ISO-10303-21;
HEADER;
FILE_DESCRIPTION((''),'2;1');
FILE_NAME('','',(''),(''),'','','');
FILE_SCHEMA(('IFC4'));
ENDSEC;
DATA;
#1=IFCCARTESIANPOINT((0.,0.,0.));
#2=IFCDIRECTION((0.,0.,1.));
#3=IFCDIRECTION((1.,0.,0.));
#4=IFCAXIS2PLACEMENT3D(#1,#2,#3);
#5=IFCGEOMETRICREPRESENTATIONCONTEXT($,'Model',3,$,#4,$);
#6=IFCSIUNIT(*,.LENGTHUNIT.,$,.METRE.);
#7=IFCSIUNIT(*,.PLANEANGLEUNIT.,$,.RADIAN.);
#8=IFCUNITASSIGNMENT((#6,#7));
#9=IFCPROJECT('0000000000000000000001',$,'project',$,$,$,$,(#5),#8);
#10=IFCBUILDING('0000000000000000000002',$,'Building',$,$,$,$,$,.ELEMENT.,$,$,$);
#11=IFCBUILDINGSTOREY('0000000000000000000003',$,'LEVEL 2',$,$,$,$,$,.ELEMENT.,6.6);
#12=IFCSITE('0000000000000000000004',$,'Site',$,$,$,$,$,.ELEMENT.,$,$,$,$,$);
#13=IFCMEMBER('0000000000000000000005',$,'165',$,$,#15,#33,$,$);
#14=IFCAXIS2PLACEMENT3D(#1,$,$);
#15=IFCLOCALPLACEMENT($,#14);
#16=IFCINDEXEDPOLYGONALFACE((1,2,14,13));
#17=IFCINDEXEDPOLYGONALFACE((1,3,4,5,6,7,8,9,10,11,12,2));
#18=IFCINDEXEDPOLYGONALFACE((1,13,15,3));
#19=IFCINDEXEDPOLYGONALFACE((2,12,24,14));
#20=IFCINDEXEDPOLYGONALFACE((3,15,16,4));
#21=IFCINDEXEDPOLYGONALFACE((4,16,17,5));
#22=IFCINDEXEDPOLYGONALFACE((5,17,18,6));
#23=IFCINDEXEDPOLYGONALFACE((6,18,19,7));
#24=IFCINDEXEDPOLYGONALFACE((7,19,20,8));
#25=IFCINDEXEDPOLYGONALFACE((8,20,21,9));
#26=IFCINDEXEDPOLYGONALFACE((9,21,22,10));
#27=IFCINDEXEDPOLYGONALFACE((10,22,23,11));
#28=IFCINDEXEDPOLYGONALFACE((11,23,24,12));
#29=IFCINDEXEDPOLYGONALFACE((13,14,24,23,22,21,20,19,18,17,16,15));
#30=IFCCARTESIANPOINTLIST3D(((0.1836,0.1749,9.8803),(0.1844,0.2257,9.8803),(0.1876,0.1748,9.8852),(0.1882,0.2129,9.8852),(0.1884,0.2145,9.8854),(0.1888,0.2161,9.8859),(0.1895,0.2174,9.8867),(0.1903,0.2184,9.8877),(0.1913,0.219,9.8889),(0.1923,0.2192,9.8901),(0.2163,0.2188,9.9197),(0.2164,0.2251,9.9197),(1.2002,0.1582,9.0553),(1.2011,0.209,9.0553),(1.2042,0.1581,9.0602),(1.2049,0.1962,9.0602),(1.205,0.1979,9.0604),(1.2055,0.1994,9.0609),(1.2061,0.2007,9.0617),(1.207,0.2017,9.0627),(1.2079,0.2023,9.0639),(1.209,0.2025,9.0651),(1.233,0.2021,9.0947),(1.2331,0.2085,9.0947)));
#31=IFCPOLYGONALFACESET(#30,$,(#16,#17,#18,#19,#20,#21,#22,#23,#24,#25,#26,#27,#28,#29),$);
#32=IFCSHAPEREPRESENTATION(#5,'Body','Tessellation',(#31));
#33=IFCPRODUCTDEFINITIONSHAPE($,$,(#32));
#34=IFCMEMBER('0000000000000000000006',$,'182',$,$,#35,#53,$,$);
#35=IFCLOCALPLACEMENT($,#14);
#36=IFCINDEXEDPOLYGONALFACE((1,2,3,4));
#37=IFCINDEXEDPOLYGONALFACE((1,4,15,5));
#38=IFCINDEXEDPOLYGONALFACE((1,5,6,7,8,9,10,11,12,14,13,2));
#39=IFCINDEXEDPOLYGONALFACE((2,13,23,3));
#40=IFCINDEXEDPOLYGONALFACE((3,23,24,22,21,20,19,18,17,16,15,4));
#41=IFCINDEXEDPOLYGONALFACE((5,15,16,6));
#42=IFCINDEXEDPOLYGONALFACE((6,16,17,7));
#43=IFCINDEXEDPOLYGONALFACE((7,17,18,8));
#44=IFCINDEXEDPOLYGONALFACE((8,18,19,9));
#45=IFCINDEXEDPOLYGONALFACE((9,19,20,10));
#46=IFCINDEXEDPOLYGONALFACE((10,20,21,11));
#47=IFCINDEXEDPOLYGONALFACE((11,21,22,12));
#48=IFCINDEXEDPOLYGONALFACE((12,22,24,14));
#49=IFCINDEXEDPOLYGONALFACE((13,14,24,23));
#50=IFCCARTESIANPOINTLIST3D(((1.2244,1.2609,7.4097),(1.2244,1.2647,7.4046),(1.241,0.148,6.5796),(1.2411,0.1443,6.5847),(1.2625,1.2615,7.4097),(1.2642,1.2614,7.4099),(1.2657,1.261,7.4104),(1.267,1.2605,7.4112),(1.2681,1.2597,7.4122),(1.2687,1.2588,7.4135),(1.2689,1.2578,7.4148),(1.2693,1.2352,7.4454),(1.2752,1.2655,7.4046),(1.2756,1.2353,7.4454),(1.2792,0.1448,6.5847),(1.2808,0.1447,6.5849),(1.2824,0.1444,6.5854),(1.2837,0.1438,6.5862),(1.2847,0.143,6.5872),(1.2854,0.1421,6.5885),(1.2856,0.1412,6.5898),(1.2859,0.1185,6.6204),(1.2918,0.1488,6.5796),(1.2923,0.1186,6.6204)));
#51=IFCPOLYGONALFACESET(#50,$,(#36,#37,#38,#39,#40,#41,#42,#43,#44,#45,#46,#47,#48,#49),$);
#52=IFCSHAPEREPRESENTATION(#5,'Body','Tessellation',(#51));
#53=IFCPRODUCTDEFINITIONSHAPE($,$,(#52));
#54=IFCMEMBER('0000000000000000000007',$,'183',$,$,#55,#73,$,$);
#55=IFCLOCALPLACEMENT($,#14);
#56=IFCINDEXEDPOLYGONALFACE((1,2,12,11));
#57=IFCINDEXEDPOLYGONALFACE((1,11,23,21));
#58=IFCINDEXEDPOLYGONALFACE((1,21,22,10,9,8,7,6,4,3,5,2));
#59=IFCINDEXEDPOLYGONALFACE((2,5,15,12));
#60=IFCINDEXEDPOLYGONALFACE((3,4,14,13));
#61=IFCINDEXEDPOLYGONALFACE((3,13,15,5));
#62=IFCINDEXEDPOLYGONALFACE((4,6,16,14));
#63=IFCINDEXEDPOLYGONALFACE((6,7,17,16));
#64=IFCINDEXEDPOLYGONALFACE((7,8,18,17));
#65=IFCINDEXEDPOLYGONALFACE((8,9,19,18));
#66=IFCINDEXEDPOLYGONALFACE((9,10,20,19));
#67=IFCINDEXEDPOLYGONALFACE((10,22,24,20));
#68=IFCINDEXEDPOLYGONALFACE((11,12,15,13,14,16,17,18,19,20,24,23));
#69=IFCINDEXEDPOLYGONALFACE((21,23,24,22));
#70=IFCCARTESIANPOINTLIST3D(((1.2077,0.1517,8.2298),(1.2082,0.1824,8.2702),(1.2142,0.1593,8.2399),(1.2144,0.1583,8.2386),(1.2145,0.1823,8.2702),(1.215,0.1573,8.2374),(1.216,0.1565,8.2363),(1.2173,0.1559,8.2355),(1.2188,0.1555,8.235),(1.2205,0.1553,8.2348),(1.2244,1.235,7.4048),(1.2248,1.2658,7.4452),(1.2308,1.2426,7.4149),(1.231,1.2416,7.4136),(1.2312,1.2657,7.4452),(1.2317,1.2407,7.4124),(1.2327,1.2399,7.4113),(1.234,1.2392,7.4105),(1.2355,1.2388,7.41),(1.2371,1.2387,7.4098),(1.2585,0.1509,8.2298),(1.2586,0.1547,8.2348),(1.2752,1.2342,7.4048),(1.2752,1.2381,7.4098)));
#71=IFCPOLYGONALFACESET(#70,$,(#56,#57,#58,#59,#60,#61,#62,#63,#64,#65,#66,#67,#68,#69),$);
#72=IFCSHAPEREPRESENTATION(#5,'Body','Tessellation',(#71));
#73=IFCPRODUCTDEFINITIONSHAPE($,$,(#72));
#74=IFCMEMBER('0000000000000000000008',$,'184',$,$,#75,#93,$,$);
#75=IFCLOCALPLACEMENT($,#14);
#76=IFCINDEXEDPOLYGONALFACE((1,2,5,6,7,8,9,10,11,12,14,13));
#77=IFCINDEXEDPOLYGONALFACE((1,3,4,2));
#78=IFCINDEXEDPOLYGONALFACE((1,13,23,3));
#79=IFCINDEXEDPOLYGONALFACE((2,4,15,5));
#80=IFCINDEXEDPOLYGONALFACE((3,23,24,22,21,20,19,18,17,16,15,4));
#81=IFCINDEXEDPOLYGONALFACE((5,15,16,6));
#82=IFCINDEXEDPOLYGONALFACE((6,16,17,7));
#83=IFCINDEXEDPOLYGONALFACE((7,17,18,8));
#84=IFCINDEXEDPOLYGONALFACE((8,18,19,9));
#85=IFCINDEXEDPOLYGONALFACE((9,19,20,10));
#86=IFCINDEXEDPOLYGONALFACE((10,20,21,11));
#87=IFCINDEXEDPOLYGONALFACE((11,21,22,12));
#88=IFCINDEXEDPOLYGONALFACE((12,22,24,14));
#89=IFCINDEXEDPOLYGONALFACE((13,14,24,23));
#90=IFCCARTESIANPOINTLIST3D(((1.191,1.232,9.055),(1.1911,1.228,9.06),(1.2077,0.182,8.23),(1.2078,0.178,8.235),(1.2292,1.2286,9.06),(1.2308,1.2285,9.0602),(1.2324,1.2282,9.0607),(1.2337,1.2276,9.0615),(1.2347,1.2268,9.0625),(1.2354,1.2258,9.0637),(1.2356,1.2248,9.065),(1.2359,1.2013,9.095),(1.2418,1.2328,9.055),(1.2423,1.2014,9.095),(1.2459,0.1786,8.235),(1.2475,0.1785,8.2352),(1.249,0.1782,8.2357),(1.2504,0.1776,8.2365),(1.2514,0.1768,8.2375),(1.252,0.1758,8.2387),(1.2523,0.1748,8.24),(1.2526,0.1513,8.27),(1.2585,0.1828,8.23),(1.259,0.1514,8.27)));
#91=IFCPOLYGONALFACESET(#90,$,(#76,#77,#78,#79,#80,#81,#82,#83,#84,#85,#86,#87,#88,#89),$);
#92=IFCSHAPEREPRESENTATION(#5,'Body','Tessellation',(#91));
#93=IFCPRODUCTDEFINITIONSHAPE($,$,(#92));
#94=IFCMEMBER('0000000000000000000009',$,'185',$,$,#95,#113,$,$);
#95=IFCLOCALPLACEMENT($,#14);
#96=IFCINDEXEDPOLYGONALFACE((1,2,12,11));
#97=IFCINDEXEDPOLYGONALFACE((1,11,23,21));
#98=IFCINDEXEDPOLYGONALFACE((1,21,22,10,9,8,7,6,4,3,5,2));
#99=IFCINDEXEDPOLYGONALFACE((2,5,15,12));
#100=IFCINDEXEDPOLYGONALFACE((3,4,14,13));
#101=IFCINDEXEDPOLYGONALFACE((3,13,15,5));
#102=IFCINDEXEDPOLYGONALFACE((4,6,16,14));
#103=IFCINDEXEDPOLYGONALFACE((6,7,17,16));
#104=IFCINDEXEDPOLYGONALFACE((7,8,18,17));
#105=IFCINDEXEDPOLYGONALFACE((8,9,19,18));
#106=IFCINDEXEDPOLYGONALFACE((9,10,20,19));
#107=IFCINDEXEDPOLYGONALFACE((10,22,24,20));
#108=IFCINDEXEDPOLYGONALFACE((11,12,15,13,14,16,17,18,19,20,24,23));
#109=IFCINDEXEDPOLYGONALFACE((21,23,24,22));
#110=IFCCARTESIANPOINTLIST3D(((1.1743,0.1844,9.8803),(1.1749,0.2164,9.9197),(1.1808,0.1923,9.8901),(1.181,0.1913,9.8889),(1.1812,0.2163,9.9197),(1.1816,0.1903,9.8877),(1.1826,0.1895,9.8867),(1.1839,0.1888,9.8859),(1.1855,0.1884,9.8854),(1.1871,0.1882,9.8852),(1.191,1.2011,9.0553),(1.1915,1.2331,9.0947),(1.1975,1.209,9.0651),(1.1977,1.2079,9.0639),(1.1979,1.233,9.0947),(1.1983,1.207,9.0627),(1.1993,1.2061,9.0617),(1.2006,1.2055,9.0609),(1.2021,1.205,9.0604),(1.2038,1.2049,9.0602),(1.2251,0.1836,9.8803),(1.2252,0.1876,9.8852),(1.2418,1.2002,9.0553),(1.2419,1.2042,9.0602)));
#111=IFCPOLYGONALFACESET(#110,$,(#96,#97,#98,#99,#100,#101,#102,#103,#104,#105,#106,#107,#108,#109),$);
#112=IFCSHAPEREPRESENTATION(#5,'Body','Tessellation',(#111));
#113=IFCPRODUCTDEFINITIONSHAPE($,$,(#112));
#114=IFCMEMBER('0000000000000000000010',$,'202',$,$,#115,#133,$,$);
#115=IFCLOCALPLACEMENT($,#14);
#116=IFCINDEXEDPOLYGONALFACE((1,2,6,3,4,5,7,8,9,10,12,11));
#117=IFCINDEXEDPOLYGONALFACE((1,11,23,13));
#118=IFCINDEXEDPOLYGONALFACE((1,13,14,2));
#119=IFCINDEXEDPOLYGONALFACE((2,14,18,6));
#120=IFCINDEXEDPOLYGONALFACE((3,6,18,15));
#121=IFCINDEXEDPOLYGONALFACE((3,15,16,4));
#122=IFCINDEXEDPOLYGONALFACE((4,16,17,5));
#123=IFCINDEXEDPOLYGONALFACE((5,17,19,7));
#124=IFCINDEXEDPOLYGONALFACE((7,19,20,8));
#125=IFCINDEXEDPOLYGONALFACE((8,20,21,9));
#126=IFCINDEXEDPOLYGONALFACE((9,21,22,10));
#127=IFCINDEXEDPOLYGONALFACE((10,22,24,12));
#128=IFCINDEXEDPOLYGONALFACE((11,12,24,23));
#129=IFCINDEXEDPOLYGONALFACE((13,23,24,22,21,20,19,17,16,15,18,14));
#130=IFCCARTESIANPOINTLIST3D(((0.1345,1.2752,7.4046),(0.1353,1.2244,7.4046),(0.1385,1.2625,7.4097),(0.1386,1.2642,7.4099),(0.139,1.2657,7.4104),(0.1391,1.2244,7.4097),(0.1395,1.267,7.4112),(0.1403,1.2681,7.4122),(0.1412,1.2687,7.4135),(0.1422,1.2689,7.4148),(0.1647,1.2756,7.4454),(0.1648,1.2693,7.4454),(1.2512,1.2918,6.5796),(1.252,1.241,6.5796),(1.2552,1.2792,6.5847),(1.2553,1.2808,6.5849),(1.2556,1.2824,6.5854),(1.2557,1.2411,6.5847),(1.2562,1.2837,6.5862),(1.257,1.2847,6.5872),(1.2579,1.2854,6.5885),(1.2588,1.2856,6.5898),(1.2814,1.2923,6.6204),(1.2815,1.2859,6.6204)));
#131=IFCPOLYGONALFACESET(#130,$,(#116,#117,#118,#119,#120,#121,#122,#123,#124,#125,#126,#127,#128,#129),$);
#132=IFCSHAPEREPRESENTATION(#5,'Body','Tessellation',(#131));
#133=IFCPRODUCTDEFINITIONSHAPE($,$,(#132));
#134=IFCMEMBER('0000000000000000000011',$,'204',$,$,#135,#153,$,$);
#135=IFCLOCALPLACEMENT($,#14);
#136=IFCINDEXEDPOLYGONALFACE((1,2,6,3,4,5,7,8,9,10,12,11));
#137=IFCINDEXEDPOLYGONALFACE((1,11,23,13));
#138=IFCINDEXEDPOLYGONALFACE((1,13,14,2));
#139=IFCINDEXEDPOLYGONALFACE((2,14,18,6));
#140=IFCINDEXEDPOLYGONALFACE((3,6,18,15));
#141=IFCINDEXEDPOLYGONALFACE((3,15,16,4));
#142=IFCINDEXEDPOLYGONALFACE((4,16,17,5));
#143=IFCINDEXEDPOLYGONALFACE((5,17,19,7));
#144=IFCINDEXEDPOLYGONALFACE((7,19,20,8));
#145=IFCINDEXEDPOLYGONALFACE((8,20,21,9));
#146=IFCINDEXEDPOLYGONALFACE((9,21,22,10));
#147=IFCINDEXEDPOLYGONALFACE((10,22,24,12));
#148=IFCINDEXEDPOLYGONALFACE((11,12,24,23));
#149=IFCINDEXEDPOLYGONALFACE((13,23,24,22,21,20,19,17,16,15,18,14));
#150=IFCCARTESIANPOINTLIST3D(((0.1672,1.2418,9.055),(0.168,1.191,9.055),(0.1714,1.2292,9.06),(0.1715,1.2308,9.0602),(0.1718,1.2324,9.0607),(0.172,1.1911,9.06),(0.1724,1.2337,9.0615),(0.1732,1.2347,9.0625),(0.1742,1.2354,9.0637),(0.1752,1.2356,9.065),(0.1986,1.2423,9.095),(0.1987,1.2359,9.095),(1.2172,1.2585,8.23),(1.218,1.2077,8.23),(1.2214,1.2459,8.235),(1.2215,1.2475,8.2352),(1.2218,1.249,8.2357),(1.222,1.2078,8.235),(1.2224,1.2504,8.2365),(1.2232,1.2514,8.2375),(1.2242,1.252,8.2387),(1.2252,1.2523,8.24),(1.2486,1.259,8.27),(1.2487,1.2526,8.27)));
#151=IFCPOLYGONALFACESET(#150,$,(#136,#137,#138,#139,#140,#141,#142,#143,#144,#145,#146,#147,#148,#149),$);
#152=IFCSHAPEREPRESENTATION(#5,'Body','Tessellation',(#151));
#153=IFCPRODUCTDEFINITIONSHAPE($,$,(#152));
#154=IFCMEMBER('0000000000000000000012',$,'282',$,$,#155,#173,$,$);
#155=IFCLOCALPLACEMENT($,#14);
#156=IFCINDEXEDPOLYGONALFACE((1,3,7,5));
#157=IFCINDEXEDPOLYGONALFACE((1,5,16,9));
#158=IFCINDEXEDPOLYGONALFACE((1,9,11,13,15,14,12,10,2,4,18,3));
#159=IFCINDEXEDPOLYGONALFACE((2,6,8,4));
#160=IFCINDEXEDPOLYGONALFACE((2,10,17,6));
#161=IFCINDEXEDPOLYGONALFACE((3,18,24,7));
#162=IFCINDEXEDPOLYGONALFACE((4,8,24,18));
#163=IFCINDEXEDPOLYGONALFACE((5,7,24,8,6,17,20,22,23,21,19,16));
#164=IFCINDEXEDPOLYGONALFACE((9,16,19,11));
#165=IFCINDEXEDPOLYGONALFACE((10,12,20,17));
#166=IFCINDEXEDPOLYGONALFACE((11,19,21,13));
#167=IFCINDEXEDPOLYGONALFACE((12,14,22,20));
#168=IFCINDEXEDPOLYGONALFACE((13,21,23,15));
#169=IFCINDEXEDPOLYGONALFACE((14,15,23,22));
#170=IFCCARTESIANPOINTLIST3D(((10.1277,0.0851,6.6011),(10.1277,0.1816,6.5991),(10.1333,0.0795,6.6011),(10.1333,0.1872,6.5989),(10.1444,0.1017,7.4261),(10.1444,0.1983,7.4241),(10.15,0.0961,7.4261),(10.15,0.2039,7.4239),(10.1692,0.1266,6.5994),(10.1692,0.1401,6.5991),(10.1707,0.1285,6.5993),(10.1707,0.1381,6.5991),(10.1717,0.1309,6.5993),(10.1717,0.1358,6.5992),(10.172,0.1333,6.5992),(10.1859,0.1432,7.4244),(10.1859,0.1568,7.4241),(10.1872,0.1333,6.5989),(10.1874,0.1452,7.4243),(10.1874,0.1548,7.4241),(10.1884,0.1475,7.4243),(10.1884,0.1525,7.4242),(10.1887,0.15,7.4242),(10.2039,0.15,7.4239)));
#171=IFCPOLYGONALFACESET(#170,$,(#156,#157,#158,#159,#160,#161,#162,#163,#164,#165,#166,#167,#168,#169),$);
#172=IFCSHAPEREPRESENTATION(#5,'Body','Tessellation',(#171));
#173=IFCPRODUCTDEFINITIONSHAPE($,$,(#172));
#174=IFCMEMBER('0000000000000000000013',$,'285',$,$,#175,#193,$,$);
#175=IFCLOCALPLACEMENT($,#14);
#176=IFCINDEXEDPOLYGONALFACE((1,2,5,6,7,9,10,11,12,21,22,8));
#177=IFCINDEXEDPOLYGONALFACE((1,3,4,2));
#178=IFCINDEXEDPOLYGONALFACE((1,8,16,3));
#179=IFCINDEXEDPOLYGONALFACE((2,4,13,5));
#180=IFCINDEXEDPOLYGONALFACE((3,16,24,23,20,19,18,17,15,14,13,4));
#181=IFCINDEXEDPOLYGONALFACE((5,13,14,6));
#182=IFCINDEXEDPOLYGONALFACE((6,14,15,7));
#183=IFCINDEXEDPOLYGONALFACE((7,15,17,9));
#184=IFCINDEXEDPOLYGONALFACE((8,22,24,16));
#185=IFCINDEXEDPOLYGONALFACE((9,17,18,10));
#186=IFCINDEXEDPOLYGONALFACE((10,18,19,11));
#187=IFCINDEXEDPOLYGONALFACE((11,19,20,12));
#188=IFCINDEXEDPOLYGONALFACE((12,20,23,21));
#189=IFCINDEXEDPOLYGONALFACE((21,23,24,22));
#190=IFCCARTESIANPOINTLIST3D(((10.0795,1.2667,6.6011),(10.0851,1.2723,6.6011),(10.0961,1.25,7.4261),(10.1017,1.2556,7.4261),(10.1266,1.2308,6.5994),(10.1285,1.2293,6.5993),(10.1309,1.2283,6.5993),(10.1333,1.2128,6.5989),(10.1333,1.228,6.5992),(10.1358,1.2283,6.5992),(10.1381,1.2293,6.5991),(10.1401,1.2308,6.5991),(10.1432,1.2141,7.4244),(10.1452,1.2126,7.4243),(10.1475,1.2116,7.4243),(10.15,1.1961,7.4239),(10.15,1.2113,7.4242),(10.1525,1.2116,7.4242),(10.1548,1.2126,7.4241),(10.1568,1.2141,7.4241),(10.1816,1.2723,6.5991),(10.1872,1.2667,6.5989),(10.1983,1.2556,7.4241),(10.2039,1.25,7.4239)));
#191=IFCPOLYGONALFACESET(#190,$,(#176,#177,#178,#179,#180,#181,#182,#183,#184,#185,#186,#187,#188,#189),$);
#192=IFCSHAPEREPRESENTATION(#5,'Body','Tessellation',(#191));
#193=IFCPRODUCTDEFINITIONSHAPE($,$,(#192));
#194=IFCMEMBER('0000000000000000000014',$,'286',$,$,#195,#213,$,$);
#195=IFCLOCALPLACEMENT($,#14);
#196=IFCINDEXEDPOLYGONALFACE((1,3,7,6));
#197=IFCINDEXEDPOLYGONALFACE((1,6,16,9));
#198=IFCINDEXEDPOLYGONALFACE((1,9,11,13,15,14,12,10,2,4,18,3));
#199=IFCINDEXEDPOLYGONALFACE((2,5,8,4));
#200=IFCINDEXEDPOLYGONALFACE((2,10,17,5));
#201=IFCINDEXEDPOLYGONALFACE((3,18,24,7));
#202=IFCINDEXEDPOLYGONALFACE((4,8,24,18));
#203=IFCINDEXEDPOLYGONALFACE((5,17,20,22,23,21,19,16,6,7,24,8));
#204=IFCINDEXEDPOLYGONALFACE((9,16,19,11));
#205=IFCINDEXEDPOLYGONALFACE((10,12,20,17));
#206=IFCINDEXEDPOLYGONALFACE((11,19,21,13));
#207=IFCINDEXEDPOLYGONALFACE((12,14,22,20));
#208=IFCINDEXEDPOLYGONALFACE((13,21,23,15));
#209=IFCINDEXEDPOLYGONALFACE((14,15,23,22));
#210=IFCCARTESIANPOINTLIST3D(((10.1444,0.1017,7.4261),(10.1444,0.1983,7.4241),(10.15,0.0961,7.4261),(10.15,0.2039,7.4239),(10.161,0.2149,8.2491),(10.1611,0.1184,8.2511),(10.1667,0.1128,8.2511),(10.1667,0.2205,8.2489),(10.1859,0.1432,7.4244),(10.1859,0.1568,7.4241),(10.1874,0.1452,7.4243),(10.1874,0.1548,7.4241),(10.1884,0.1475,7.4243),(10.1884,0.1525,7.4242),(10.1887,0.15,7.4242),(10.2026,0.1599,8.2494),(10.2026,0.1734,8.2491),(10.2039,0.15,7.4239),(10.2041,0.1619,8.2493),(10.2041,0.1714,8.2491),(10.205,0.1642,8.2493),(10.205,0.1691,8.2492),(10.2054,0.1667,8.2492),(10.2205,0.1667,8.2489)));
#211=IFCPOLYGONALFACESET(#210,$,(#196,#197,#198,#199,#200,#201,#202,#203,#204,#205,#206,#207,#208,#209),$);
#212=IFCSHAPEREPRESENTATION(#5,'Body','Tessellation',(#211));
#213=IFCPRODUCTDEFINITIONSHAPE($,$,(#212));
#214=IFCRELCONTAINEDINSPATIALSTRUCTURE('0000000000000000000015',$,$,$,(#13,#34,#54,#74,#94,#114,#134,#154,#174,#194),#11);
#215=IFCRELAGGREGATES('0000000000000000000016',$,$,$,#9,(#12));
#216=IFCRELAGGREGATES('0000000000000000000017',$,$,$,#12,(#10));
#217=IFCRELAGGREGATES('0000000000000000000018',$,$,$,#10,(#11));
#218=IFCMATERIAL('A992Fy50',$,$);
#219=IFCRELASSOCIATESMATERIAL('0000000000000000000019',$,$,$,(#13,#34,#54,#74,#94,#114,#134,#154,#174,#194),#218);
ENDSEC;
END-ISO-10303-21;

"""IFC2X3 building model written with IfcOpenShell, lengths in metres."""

from ifc_helpers import new_model, si_unit, frame, origin_with_axes, origin_2d_with_axis, place, context, project, spatial, l_section, extrude, material, element, save


model = new_model("IFC2X3")

# Units and contexts
model_context = context("Model", 3, world=origin_with_axes())
ifc_project = project(units=[si_unit("LENGTHUNIT", "METRE"), si_unit("PLANEANGLEUNIT", "RADIAN")], contexts=[model_context])

# Site, building, storey
site = spatial("IfcSite", under=ifc_project, Name="Site", CompositionType="ELEMENT")
building = spatial("IfcBuilding", under=site, Name="Building", CompositionType="ELEMENT")
storey = spatial("IfcBuildingStorey", under=building, Name="LEVEL 2", CompositionType="ELEMENT", Elevation=6.6)

# Shared definitions
ifc_material = material(Name="A992Fy50")

# Members
member_1_placement = place(None, frame((1.2167, 0.1833, 9.075), z_axis=(-0.77644, 0.012729, 0.630062), x_axis=(-0.016391, -0.999866, 0.0)))
element("IfcMember", 1, at=member_1_placement, inside=storey, material=ifc_material, Name="165", context=model_context, shape_type="SweptSolid", body=[
    extrude(l_section(Depth=0.0508, Width=0.0508, Thickness=0.0063, FilletRadius=0.0063, at=origin_2d_with_axis()), origin_with_axes(), (0.0, 0.0, 1.0), 1.3094),
])
member_2_placement = place(None, frame((1.2667, 0.1333, 6.6), z_axis=(-0.012004, 0.804243, 0.594179), x_axis=(-0.999889, -0.014924, 0.0)))
element("IfcMember", 2, at=member_2_placement, inside=storey, material=ifc_material, Name="182", context=model_context, shape_type="SweptSolid", body=[
    extrude(l_section(Depth=0.0508, Width=0.0508, Thickness=0.0063, FilletRadius=0.0063, at=origin_2d_with_axis()), origin_with_axes(), (0.0, 0.0, 1.0), 1.3885),
])
member_3_placement = place(None, frame((1.25, 1.25, 7.425), z_axis=(-0.012239, -0.795513, 0.605813), x_axis=(0.999882, -0.015383, 0.0)))
element("IfcMember", 3, at=member_3_placement, inside=storey, material=ifc_material, Name="183", context=model_context, shape_type="SweptSolid", body=[
    extrude(l_section(Depth=0.0508, Width=0.0508, Thickness=0.0063, FilletRadius=0.0063, at=origin_2d_with_axis()), origin_with_axes(), (0.0, 0.0, 1.0), 1.3618),
])
member_4_placement = place(None, frame((1.2333, 0.1667, 8.25), z_axis=(-0.01248, 0.786257, 0.617773), x_axis=(-0.999889, -0.014924, 0.0)))
element("IfcMember", 4, at=member_4_placement, inside=storey, material=ifc_material, Name="184", context=model_context, shape_type="SweptSolid", body=[
    extrude(l_section(Depth=0.0508, Width=0.0508, Thickness=0.0063, FilletRadius=0.0063, at=origin_2d_with_axis()), origin_with_axes(), (0.0, 0.0, 1.0), 1.3354),
])
member_5_placement = place(None, frame((1.2167, 1.2167, 9.075), z_axis=(-0.012729, -0.77644, 0.630062), x_axis=(0.999866, -0.016391, 0.0)))
element("IfcMember", 5, at=member_5_placement, inside=storey, material=ifc_material, Name="185", context=model_context, shape_type="SweptSolid", body=[
    extrude(l_section(Depth=0.0508, Width=0.0508, Thickness=0.0063, FilletRadius=0.0063, at=origin_2d_with_axis()), origin_with_axes(), (0.0, 0.0, 1.0), 1.3094),
])
member_6_placement = place(None, frame((1.2667, 1.2667, 6.6), z_axis=(-0.804243, -0.012004, 0.594179), x_axis=(0.014924, -0.999889, 0.0)))
element("IfcMember", 6, at=member_6_placement, inside=storey, material=ifc_material, Name="202", context=model_context, shape_type="SweptSolid", body=[
    extrude(l_section(Depth=0.0508, Width=0.0508, Thickness=0.0063, FilletRadius=0.0063, at=origin_2d_with_axis()), origin_with_axes(), (0.0, 0.0, 1.0), 1.3885),
])
member_7_placement = place(None, frame((1.2333, 1.2333, 8.25), z_axis=(-0.786257, -0.01248, 0.617773), x_axis=(0.014924, -0.999889, 0.0)))
element("IfcMember", 7, at=member_7_placement, inside=storey, material=ifc_material, Name="204", context=model_context, shape_type="SweptSolid", body=[
    extrude(l_section(Depth=0.0508, Width=0.0508, Thickness=0.0063, FilletRadius=0.0063, at=origin_2d_with_axis()), origin_with_axes(), (0.0, 0.0, 1.0), 1.3354),
])
for number, where, z_axis, x_axis, name in (
    (8, (10.1333, 0.1333, 6.6), (0.020194, 0.020194, 0.999592), (-0.707107, 0.707107, 0.0), "282"),
    (9, (10.1333, 1.2667, 6.6), (0.020194, -0.020194, 0.999592), (0.707107, 0.707107, 0.0), "285"),
    (10, (10.15, 0.15, 7.425), (0.020194, 0.020194, 0.999592), (-0.707107, 0.707107, 0.0), "286"),
):
    element("IfcMember", number, at=place(None, frame(where, z_axis=z_axis, x_axis=x_axis)), inside=storey, material=ifc_material, Name=name, context=model_context, shape_type="SweptSolid", body=[
        extrude(l_section(Depth=0.0762, Width=0.0762, Thickness=0.0079, FilletRadius=0.0096, at=origin_2d_with_axis()), origin_with_axes(), (0.0, 0.0, 1.0), 0.8253),
    ])

save(model, "model.ifc")
